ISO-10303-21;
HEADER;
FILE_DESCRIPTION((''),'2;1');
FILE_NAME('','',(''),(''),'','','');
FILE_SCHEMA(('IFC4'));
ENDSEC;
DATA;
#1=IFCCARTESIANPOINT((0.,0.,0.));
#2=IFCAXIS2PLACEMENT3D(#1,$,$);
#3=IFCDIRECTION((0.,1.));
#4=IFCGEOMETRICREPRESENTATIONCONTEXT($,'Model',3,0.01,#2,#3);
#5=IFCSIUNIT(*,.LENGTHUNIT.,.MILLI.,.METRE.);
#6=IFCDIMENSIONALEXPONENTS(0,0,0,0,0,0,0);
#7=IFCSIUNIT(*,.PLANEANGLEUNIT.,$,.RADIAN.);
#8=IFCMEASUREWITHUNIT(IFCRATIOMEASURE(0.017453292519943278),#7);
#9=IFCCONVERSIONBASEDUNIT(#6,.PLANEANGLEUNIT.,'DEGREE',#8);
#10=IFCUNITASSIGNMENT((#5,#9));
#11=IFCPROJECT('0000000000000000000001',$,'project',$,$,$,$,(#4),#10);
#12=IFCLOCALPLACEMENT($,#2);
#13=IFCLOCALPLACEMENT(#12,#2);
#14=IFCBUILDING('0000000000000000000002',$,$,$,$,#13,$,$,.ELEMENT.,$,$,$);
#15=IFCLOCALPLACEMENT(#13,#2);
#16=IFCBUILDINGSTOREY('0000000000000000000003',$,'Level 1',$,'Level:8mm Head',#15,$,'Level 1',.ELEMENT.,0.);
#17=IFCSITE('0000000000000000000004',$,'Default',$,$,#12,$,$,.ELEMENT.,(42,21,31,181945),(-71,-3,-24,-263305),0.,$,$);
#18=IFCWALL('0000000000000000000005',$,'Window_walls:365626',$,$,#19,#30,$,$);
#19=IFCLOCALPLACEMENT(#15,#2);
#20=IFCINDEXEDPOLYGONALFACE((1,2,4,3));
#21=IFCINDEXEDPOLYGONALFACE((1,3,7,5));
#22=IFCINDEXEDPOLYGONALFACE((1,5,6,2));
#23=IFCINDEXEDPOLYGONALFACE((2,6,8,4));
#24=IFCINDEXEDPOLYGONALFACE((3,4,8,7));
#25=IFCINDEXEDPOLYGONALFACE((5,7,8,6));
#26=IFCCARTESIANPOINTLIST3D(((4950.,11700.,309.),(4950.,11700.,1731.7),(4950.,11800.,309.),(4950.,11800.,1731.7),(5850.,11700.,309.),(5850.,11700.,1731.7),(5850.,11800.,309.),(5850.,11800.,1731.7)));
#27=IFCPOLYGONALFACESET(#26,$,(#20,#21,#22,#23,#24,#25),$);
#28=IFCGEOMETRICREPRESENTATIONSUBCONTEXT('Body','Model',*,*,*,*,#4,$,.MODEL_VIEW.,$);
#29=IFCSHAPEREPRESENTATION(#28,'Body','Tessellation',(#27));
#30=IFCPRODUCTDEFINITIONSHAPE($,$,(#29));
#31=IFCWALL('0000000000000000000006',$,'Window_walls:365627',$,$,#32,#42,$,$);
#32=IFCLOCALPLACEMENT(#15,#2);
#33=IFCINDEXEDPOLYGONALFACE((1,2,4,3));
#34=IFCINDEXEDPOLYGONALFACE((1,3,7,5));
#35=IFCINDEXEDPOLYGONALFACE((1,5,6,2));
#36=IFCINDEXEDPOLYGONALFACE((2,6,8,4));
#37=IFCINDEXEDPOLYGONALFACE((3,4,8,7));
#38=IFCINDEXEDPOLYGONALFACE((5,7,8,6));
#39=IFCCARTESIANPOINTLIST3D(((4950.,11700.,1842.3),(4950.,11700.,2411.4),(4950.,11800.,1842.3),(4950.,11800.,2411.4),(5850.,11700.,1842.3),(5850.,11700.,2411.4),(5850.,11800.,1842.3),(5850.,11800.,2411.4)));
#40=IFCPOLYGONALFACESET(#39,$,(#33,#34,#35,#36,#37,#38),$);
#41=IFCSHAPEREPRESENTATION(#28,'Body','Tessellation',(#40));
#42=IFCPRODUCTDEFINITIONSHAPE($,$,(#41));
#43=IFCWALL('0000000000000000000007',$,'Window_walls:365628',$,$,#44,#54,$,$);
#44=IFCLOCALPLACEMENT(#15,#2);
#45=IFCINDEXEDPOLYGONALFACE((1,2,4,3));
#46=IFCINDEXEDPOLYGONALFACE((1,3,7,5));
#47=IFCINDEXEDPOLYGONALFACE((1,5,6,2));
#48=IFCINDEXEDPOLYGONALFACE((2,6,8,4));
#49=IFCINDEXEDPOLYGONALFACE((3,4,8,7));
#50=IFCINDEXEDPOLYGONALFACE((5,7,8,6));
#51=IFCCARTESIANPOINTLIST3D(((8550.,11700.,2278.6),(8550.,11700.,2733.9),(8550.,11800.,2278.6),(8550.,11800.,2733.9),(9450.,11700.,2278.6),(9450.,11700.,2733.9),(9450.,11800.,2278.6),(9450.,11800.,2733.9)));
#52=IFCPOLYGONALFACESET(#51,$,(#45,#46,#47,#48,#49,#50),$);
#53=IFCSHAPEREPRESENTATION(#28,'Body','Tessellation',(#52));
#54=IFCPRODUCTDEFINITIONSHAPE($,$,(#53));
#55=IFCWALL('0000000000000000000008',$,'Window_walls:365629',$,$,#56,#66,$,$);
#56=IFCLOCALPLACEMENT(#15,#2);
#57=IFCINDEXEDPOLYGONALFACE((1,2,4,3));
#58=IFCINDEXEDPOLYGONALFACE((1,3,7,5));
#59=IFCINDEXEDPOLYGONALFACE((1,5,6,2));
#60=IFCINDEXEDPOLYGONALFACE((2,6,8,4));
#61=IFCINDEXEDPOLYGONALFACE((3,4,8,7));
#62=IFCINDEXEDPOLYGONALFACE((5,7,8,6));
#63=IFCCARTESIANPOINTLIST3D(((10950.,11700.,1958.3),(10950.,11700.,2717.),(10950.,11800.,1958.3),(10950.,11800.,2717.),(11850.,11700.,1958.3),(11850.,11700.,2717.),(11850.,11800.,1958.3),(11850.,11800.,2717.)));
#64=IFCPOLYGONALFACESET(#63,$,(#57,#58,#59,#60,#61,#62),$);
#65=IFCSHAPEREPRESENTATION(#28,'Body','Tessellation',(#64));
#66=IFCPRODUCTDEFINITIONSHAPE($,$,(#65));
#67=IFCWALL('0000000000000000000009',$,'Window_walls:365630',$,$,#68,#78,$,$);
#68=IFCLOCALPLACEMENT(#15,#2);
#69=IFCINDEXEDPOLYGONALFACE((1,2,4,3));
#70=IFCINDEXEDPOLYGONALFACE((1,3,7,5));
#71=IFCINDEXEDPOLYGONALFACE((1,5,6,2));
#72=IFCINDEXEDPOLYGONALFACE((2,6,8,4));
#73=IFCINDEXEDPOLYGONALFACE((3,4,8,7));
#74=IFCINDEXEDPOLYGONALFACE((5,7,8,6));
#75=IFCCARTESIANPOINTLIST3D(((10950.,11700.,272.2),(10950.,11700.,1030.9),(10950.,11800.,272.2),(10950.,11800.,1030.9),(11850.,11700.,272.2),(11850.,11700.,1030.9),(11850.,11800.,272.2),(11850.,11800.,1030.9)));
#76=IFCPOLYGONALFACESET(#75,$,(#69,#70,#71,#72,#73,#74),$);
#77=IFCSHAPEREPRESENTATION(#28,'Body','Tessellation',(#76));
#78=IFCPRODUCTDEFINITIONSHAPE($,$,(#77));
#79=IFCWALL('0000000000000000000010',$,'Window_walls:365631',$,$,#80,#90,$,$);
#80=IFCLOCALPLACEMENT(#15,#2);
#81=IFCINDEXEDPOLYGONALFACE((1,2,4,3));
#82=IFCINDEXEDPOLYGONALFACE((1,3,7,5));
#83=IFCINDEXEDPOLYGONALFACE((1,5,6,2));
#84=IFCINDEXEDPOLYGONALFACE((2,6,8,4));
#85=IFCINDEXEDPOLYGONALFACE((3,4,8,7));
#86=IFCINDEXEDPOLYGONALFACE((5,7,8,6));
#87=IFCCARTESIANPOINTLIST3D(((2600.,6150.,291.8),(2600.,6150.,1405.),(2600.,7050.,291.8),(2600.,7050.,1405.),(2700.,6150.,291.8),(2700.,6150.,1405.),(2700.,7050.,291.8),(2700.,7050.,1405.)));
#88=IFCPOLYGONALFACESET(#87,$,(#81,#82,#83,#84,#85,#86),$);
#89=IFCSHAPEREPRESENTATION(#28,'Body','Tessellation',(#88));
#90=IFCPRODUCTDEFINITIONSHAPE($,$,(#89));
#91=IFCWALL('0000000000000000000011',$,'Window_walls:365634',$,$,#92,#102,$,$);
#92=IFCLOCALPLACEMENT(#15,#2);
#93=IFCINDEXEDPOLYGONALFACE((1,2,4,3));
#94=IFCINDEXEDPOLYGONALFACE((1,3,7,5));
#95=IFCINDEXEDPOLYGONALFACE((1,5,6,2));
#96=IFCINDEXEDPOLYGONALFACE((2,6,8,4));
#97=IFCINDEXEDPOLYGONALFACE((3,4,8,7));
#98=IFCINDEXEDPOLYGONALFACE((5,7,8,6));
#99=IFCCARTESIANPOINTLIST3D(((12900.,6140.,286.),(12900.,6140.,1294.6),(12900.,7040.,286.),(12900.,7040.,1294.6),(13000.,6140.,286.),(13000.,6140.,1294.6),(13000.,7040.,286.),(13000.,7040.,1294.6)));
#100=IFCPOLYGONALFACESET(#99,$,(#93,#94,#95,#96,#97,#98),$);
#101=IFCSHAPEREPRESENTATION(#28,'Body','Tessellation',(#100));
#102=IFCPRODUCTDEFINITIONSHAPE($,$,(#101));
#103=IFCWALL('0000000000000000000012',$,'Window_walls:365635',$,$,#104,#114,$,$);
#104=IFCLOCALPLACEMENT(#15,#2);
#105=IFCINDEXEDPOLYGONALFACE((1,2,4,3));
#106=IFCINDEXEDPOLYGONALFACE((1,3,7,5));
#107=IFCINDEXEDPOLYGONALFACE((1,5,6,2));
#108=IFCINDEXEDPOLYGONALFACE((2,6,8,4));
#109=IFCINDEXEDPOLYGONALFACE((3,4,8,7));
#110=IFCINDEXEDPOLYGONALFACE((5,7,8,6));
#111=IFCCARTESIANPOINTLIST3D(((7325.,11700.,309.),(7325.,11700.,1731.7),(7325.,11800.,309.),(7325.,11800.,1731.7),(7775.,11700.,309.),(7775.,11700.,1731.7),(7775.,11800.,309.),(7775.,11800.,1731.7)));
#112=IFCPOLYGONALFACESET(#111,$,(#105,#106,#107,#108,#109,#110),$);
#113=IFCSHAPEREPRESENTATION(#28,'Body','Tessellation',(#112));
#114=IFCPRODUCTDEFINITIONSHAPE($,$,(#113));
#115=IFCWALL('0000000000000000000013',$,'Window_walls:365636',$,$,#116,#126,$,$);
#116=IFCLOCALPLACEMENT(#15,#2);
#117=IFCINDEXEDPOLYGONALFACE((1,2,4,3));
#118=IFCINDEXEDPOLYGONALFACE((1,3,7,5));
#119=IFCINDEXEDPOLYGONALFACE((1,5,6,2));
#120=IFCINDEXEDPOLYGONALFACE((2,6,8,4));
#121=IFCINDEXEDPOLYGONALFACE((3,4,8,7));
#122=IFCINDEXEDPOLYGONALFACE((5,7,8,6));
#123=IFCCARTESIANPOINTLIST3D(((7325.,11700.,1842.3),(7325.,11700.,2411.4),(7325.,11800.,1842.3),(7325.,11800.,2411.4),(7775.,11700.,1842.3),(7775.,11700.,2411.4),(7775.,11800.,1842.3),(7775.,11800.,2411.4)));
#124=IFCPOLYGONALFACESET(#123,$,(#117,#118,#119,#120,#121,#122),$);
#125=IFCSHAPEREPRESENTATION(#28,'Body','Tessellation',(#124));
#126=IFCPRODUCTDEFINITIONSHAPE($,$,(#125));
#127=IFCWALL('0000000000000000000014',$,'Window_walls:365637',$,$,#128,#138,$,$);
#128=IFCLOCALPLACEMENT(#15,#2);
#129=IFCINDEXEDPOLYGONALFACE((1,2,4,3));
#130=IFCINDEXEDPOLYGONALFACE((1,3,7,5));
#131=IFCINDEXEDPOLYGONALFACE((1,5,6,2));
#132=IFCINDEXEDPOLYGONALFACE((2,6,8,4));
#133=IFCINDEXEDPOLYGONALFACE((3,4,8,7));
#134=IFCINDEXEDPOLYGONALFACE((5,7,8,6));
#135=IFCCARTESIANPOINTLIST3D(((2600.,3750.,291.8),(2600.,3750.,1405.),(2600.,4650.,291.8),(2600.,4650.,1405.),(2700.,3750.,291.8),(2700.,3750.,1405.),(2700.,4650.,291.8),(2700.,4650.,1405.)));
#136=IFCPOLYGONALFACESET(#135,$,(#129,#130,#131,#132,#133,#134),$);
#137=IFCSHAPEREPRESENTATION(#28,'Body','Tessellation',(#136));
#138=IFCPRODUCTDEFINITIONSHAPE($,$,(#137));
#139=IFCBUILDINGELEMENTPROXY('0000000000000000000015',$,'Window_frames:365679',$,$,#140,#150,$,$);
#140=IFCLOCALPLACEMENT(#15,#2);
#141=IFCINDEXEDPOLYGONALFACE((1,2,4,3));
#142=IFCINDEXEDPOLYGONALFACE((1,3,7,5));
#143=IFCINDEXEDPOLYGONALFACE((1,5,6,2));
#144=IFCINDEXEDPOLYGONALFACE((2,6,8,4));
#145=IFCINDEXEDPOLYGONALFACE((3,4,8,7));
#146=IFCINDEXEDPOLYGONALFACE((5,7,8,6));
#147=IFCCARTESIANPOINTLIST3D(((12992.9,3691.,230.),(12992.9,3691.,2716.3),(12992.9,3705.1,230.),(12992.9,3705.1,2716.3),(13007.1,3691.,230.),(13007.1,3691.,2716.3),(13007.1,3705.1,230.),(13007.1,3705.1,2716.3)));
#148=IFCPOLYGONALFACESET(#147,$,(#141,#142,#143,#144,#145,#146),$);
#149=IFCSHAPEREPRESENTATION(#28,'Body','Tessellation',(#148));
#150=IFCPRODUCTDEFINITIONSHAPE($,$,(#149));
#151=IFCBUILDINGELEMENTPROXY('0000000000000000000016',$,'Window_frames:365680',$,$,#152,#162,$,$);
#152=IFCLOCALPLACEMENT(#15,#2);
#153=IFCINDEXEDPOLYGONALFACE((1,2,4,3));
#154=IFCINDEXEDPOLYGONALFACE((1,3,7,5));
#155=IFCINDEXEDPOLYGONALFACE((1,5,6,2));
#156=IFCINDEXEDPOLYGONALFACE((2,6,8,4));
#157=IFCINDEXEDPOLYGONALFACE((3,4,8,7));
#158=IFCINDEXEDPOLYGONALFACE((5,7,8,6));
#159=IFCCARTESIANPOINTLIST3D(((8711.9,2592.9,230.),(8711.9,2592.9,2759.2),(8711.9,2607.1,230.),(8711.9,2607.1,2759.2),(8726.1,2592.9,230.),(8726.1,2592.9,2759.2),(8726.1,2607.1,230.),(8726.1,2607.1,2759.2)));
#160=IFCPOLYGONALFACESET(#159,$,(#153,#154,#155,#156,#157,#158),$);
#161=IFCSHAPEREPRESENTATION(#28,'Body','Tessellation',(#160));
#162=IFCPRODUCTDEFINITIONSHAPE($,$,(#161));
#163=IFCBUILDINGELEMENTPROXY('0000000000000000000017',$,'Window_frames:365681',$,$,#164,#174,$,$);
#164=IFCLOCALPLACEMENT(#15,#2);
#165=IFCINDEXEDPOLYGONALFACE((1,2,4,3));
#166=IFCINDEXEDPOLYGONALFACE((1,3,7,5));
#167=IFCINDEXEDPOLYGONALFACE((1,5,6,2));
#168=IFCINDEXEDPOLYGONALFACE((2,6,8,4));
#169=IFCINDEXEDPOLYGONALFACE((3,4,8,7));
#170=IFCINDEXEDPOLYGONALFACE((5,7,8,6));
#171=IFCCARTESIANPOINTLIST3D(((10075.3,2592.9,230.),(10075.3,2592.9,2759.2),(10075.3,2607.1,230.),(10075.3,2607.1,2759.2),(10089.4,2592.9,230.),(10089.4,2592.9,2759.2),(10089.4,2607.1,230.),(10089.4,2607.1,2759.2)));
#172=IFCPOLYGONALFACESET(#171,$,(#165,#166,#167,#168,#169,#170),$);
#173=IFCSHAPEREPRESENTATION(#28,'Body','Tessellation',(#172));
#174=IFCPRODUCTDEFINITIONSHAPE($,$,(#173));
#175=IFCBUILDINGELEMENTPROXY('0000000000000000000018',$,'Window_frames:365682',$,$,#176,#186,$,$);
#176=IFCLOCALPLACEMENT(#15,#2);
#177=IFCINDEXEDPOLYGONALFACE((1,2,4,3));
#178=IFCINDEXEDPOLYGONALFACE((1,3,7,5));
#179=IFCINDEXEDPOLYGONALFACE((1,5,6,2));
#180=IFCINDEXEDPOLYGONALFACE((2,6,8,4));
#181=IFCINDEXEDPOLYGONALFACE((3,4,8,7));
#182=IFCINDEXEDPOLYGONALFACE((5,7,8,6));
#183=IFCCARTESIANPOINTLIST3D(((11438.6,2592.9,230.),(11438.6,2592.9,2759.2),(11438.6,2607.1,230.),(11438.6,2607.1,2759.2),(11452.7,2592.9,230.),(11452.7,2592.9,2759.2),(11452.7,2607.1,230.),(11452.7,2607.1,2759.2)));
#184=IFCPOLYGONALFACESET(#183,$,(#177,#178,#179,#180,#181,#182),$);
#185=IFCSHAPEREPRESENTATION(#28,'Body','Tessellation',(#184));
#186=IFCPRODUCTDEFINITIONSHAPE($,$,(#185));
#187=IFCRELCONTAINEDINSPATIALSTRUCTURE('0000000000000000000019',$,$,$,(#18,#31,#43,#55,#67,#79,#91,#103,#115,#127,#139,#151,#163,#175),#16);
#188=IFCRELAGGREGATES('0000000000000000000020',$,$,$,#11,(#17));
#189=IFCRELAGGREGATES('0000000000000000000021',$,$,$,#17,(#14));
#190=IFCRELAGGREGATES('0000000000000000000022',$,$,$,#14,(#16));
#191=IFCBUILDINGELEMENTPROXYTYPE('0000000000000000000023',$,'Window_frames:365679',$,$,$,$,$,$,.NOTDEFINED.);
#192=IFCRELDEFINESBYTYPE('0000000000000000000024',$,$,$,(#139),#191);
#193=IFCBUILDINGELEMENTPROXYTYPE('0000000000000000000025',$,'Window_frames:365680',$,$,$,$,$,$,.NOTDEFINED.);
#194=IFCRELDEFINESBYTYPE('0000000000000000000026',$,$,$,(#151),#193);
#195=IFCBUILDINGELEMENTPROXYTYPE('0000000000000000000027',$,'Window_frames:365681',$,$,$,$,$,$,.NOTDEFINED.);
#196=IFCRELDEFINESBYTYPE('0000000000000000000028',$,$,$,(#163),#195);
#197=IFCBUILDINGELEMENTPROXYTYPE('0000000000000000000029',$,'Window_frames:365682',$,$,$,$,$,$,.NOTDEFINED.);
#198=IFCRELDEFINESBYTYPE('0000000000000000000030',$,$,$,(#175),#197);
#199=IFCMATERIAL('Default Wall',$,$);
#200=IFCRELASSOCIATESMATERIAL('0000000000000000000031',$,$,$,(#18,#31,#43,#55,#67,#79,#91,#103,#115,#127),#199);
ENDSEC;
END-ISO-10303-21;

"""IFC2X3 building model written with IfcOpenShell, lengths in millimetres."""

from ifc_helpers import new_model, entity, si_unit, converted_unit, direction, frame, frame_2d, origin, place, context, subcontext, project, spatial, rectangle, extrude, material, type_object, element, save


model = new_model("IFC2X3")

# Units and contexts
model_context = context("Model", 3, precision=0.01, world=origin(), true_north=direction((0.0, 1.0)))
body_context = subcontext(model_context, "Body", "Model", "MODEL_VIEW")
ifc_project = project(units=[si_unit("LENGTHUNIT", "METRE", prefix="MILLI"), converted_unit("PLANEANGLEUNIT", "DEGREE", entity("IfcRatioMeasure", 0.017453292519943278), si_unit("PLANEANGLEUNIT", "RADIAN"), dimensions=[0, 0, 0, 0, 0, 0, 0])], contexts=[model_context])

# Site, building, storey
site_placement = place(None, origin())
site = spatial("IfcSite", under=ifc_project, at=site_placement, Name="Default", CompositionType="ELEMENT", RefLatitude=(42, 21, 31, 181945), RefLongitude=(-71, -3, -24, -263305), RefElevation=0.0)
building_placement = place(site_placement, origin())
building = spatial("IfcBuilding", under=site, at=building_placement, CompositionType="ELEMENT")
storey_placement = place(building_placement, origin())
storey = spatial("IfcBuildingStorey", under=building, at=storey_placement, Name="Level 1", ObjectType="Level:8mm Head", LongName="Level 1", CompositionType="ELEMENT", Elevation=0.0)

# Walls
ifc_material = material(Name="Default Wall")
wall_1_placement = place(storey_placement, frame((4950.0, 11700.0, 309.0)))
element("IfcWall", 1, at=wall_1_placement, inside=storey, material=ifc_material, Name="Window_walls:365626", context=body_context, shape_type="SweptSolid", body=[
    extrude(rectangle(XDim=100.0, YDim=900.0, at=frame_2d((0.0, 0.0), x_axis=(1.0, 0.0))), frame((450.0, 50.0, 0.0), z_axis=(0.0, 0.0, 1.0), x_axis=(0.0, -1.0, 0.0)), (0.0, 0.0, 1.0), 1422.7),
])
wall_2_placement = place(storey_placement, frame((4950.0, 11700.0, 1842.3)))
element("IfcWall", 2, at=wall_2_placement, inside=storey, material=ifc_material, Name="Window_walls:365627", context=body_context, shape_type="SweptSolid", body=[
    extrude(rectangle(XDim=100.0, YDim=900.0, at=frame_2d((0.0, 0.0), x_axis=(1.0, 0.0))), frame((450.0, 50.0, 0.0), z_axis=(0.0, 0.0, 1.0), x_axis=(0.0, -1.0, 0.0)), (0.0, 0.0, 1.0), 569.1),
])
wall_3_placement = place(storey_placement, frame((8550.0, 11700.0, 2278.6)))
element("IfcWall", 3, at=wall_3_placement, inside=storey, material=ifc_material, Name="Window_walls:365628", context=body_context, shape_type="SweptSolid", body=[
    extrude(rectangle(XDim=900.0, YDim=100.0, at=frame_2d((0.0, 0.0), x_axis=(1.0, 0.0))), frame((450.0, 50.0, 0.0), z_axis=(0.0, 0.0, 1.0), x_axis=(-1.0, 0.0, 0.0)), (0.0, 0.0, 1.0), 455.2),
])
wall_4_placement = place(storey_placement, frame((10950.0, 11700.0, 1958.3)))
element("IfcWall", 4, at=wall_4_placement, inside=storey, material=ifc_material, Name="Window_walls:365629", context=body_context, shape_type="SweptSolid", body=[
    extrude(rectangle(XDim=900.0, YDim=100.0, at=frame_2d((0.0, 0.0), x_axis=(1.0, 0.0))), frame((450.0, 50.0, 0.0), z_axis=(0.0, 0.0, 1.0), x_axis=(-1.0, 0.0, 0.0)), (0.0, 0.0, 1.0), 758.7),
])
wall_5_placement = place(storey_placement, frame((10950.0, 11700.0, 272.2)))
element("IfcWall", 5, at=wall_5_placement, inside=storey, material=ifc_material, Name="Window_walls:365630", context=body_context, shape_type="SweptSolid", body=[
    extrude(rectangle(XDim=100.0, YDim=900.0, at=frame_2d((0.0, 0.0), x_axis=(1.0, 0.0))), frame((450.0, 50.0, 0.0), z_axis=(0.0, 0.0, 1.0), x_axis=(0.0, -1.0, 0.0)), (0.0, 0.0, 1.0), 758.8),
])
wall_6_placement = place(storey_placement, frame((2600.0, 6150.0, 291.8), z_axis=(0.0, 0.0, 1.0), x_axis=(0.0, 1.0, 0.0)))
element("IfcWall", 6, at=wall_6_placement, inside=storey, material=ifc_material, Name="Window_walls:365631", context=body_context, shape_type="SweptSolid", body=[
    extrude(rectangle(XDim=100.0, YDim=900.0, at=frame_2d((0.0, 0.0), x_axis=(1.0, 0.0))), frame((450.0, -50.0, 0.0), z_axis=(0.0, 0.0, 1.0), x_axis=(0.0, -1.0, 0.0)), (0.0, 0.0, 1.0), 1113.1),
])
wall_7_placement = place(storey_placement, frame((12900.0, 6140.0, 286.0), z_axis=(0.0, 0.0, 1.0), x_axis=(0.0, 1.0, 0.0)))
element("IfcWall", 7, at=wall_7_placement, inside=storey, material=ifc_material, Name="Window_walls:365634", context=body_context, shape_type="SweptSolid", body=[
    extrude(rectangle(XDim=100.0, YDim=900.0, at=frame_2d((0.0, 0.0), x_axis=(1.0, 0.0))), frame((450.0, -50.0, 0.0), z_axis=(0.0, 0.0, 1.0), x_axis=(0.0, 1.0, 0.0)), (0.0, 0.0, 1.0), 1008.6),
])
wall_8_placement = place(storey_placement, frame((7325.0, 11700.0, 309.0)))
element("IfcWall", 8, at=wall_8_placement, inside=storey, material=ifc_material, Name="Window_walls:365635", context=body_context, shape_type="SweptSolid", body=[
    extrude(rectangle(XDim=100.0, YDim=450.0, at=frame_2d((0.0, 0.0), x_axis=(1.0, 0.0))), frame((225.0, 50.0, 0.0), z_axis=(0.0, 0.0, 1.0), x_axis=(0.0, -1.0, 0.0)), (0.0, 0.0, 1.0), 1422.7),
])
wall_9_placement = place(storey_placement, frame((7325.0, 11700.0, 1842.3)))
element("IfcWall", 9, at=wall_9_placement, inside=storey, material=ifc_material, Name="Window_walls:365636", context=body_context, shape_type="SweptSolid", body=[
    extrude(rectangle(XDim=100.0, YDim=450.0, at=frame_2d((0.0, 0.0), x_axis=(1.0, 0.0))), frame((225.0, 50.0, 0.0), z_axis=(0.0, 0.0, 1.0), x_axis=(0.0, -1.0, 0.0)), (0.0, 0.0, 1.0), 569.1),
])
wall_10_placement = place(storey_placement, frame((2600.0, 3750.0, 291.8), z_axis=(0.0, 0.0, 1.0), x_axis=(0.0, 1.0, 0.0)))
element("IfcWall", 10, at=wall_10_placement, inside=storey, material=ifc_material, Name="Window_walls:365637", context=body_context, shape_type="SweptSolid", body=[
    extrude(rectangle(XDim=100.0, YDim=900.0, at=frame_2d((0.0, 0.0), x_axis=(1.0, 0.0))), frame((450.0, -50.0, 0.0), z_axis=(0.0, 0.0, 1.0), x_axis=(0.0, -1.0, 0.0)), (0.0, 0.0, 1.0), 1113.1),
])

# Building element proxies
building_element_proxy_type_1 = type_object("IfcBuildingElementProxyType", Name="Window_frames:365679", PredefinedType="NOTDEFINED")
proxy_1_placement = place(storey_placement, origin())
element("IfcBuildingElementProxy", 11, at=proxy_1_placement, inside=storey, type_object=building_element_proxy_type_1, Name="Window_frames:365679", context=body_context, shape_type="SweptSolid", body=[
    extrude(rectangle(XDim=14.1, YDim=14.1, at=frame_2d((0.0, 0.0), x_axis=(1.0, 0.0))), frame((13000.0, 3698.0, 230.0), z_axis=(0.0, 0.0, 1.0), x_axis=(-1.0, 0.0, 0.0)), (0.0, 0.0, 1.0), 2486.3),
])
building_element_proxy_type_2 = type_object("IfcBuildingElementProxyType", Name="Window_frames:365680", PredefinedType="NOTDEFINED")
proxy_2_placement = place(storey_placement, origin())
element("IfcBuildingElementProxy", 12, at=proxy_2_placement, inside=storey, type_object=building_element_proxy_type_2, Name="Window_frames:365680", context=body_context, shape_type="SweptSolid", body=[
    extrude(rectangle(XDim=14.1, YDim=14.1, at=frame_2d((0.0, 0.0), x_axis=(1.0, 0.0))), frame((8719.0, 2600.0, 230.0), z_axis=(0.0, 0.0, 1.0), x_axis=(0.0, -1.0, 0.0)), (0.0, 0.0, 1.0), 2529.2),
])
building_element_proxy_type_3 = type_object("IfcBuildingElementProxyType", Name="Window_frames:365681", PredefinedType="NOTDEFINED")
proxy_3_placement = place(storey_placement, origin())
element("IfcBuildingElementProxy", 13, at=proxy_3_placement, inside=storey, type_object=building_element_proxy_type_3, Name="Window_frames:365681", context=body_context, shape_type="SweptSolid", body=[
    extrude(rectangle(XDim=14.1, YDim=14.1, at=frame_2d((0.0, 0.0), x_axis=(1.0, 0.0))), frame((10082.3, 2600.0, 230.0), z_axis=(0.0, 0.0, 1.0), x_axis=(0.0, -1.0, 0.0)), (0.0, 0.0, 1.0), 2529.2),
])
building_element_proxy_type_4 = type_object("IfcBuildingElementProxyType", Name="Window_frames:365682", PredefinedType="NOTDEFINED")
proxy_4_placement = place(storey_placement, origin())
element("IfcBuildingElementProxy", 14, at=proxy_4_placement, inside=storey, type_object=building_element_proxy_type_4, Name="Window_frames:365682", context=body_context, shape_type="SweptSolid", body=[
    extrude(rectangle(XDim=14.1, YDim=14.1, at=frame_2d((0.0, 0.0), x_axis=(1.0, 0.0))), frame((11445.7, 2600.0, 230.0), z_axis=(0.0, 0.0, 1.0), x_axis=(0.0, -1.0, 0.0)), (0.0, 0.0, 1.0), 2529.2),
])

save(model, "model.ifc")
